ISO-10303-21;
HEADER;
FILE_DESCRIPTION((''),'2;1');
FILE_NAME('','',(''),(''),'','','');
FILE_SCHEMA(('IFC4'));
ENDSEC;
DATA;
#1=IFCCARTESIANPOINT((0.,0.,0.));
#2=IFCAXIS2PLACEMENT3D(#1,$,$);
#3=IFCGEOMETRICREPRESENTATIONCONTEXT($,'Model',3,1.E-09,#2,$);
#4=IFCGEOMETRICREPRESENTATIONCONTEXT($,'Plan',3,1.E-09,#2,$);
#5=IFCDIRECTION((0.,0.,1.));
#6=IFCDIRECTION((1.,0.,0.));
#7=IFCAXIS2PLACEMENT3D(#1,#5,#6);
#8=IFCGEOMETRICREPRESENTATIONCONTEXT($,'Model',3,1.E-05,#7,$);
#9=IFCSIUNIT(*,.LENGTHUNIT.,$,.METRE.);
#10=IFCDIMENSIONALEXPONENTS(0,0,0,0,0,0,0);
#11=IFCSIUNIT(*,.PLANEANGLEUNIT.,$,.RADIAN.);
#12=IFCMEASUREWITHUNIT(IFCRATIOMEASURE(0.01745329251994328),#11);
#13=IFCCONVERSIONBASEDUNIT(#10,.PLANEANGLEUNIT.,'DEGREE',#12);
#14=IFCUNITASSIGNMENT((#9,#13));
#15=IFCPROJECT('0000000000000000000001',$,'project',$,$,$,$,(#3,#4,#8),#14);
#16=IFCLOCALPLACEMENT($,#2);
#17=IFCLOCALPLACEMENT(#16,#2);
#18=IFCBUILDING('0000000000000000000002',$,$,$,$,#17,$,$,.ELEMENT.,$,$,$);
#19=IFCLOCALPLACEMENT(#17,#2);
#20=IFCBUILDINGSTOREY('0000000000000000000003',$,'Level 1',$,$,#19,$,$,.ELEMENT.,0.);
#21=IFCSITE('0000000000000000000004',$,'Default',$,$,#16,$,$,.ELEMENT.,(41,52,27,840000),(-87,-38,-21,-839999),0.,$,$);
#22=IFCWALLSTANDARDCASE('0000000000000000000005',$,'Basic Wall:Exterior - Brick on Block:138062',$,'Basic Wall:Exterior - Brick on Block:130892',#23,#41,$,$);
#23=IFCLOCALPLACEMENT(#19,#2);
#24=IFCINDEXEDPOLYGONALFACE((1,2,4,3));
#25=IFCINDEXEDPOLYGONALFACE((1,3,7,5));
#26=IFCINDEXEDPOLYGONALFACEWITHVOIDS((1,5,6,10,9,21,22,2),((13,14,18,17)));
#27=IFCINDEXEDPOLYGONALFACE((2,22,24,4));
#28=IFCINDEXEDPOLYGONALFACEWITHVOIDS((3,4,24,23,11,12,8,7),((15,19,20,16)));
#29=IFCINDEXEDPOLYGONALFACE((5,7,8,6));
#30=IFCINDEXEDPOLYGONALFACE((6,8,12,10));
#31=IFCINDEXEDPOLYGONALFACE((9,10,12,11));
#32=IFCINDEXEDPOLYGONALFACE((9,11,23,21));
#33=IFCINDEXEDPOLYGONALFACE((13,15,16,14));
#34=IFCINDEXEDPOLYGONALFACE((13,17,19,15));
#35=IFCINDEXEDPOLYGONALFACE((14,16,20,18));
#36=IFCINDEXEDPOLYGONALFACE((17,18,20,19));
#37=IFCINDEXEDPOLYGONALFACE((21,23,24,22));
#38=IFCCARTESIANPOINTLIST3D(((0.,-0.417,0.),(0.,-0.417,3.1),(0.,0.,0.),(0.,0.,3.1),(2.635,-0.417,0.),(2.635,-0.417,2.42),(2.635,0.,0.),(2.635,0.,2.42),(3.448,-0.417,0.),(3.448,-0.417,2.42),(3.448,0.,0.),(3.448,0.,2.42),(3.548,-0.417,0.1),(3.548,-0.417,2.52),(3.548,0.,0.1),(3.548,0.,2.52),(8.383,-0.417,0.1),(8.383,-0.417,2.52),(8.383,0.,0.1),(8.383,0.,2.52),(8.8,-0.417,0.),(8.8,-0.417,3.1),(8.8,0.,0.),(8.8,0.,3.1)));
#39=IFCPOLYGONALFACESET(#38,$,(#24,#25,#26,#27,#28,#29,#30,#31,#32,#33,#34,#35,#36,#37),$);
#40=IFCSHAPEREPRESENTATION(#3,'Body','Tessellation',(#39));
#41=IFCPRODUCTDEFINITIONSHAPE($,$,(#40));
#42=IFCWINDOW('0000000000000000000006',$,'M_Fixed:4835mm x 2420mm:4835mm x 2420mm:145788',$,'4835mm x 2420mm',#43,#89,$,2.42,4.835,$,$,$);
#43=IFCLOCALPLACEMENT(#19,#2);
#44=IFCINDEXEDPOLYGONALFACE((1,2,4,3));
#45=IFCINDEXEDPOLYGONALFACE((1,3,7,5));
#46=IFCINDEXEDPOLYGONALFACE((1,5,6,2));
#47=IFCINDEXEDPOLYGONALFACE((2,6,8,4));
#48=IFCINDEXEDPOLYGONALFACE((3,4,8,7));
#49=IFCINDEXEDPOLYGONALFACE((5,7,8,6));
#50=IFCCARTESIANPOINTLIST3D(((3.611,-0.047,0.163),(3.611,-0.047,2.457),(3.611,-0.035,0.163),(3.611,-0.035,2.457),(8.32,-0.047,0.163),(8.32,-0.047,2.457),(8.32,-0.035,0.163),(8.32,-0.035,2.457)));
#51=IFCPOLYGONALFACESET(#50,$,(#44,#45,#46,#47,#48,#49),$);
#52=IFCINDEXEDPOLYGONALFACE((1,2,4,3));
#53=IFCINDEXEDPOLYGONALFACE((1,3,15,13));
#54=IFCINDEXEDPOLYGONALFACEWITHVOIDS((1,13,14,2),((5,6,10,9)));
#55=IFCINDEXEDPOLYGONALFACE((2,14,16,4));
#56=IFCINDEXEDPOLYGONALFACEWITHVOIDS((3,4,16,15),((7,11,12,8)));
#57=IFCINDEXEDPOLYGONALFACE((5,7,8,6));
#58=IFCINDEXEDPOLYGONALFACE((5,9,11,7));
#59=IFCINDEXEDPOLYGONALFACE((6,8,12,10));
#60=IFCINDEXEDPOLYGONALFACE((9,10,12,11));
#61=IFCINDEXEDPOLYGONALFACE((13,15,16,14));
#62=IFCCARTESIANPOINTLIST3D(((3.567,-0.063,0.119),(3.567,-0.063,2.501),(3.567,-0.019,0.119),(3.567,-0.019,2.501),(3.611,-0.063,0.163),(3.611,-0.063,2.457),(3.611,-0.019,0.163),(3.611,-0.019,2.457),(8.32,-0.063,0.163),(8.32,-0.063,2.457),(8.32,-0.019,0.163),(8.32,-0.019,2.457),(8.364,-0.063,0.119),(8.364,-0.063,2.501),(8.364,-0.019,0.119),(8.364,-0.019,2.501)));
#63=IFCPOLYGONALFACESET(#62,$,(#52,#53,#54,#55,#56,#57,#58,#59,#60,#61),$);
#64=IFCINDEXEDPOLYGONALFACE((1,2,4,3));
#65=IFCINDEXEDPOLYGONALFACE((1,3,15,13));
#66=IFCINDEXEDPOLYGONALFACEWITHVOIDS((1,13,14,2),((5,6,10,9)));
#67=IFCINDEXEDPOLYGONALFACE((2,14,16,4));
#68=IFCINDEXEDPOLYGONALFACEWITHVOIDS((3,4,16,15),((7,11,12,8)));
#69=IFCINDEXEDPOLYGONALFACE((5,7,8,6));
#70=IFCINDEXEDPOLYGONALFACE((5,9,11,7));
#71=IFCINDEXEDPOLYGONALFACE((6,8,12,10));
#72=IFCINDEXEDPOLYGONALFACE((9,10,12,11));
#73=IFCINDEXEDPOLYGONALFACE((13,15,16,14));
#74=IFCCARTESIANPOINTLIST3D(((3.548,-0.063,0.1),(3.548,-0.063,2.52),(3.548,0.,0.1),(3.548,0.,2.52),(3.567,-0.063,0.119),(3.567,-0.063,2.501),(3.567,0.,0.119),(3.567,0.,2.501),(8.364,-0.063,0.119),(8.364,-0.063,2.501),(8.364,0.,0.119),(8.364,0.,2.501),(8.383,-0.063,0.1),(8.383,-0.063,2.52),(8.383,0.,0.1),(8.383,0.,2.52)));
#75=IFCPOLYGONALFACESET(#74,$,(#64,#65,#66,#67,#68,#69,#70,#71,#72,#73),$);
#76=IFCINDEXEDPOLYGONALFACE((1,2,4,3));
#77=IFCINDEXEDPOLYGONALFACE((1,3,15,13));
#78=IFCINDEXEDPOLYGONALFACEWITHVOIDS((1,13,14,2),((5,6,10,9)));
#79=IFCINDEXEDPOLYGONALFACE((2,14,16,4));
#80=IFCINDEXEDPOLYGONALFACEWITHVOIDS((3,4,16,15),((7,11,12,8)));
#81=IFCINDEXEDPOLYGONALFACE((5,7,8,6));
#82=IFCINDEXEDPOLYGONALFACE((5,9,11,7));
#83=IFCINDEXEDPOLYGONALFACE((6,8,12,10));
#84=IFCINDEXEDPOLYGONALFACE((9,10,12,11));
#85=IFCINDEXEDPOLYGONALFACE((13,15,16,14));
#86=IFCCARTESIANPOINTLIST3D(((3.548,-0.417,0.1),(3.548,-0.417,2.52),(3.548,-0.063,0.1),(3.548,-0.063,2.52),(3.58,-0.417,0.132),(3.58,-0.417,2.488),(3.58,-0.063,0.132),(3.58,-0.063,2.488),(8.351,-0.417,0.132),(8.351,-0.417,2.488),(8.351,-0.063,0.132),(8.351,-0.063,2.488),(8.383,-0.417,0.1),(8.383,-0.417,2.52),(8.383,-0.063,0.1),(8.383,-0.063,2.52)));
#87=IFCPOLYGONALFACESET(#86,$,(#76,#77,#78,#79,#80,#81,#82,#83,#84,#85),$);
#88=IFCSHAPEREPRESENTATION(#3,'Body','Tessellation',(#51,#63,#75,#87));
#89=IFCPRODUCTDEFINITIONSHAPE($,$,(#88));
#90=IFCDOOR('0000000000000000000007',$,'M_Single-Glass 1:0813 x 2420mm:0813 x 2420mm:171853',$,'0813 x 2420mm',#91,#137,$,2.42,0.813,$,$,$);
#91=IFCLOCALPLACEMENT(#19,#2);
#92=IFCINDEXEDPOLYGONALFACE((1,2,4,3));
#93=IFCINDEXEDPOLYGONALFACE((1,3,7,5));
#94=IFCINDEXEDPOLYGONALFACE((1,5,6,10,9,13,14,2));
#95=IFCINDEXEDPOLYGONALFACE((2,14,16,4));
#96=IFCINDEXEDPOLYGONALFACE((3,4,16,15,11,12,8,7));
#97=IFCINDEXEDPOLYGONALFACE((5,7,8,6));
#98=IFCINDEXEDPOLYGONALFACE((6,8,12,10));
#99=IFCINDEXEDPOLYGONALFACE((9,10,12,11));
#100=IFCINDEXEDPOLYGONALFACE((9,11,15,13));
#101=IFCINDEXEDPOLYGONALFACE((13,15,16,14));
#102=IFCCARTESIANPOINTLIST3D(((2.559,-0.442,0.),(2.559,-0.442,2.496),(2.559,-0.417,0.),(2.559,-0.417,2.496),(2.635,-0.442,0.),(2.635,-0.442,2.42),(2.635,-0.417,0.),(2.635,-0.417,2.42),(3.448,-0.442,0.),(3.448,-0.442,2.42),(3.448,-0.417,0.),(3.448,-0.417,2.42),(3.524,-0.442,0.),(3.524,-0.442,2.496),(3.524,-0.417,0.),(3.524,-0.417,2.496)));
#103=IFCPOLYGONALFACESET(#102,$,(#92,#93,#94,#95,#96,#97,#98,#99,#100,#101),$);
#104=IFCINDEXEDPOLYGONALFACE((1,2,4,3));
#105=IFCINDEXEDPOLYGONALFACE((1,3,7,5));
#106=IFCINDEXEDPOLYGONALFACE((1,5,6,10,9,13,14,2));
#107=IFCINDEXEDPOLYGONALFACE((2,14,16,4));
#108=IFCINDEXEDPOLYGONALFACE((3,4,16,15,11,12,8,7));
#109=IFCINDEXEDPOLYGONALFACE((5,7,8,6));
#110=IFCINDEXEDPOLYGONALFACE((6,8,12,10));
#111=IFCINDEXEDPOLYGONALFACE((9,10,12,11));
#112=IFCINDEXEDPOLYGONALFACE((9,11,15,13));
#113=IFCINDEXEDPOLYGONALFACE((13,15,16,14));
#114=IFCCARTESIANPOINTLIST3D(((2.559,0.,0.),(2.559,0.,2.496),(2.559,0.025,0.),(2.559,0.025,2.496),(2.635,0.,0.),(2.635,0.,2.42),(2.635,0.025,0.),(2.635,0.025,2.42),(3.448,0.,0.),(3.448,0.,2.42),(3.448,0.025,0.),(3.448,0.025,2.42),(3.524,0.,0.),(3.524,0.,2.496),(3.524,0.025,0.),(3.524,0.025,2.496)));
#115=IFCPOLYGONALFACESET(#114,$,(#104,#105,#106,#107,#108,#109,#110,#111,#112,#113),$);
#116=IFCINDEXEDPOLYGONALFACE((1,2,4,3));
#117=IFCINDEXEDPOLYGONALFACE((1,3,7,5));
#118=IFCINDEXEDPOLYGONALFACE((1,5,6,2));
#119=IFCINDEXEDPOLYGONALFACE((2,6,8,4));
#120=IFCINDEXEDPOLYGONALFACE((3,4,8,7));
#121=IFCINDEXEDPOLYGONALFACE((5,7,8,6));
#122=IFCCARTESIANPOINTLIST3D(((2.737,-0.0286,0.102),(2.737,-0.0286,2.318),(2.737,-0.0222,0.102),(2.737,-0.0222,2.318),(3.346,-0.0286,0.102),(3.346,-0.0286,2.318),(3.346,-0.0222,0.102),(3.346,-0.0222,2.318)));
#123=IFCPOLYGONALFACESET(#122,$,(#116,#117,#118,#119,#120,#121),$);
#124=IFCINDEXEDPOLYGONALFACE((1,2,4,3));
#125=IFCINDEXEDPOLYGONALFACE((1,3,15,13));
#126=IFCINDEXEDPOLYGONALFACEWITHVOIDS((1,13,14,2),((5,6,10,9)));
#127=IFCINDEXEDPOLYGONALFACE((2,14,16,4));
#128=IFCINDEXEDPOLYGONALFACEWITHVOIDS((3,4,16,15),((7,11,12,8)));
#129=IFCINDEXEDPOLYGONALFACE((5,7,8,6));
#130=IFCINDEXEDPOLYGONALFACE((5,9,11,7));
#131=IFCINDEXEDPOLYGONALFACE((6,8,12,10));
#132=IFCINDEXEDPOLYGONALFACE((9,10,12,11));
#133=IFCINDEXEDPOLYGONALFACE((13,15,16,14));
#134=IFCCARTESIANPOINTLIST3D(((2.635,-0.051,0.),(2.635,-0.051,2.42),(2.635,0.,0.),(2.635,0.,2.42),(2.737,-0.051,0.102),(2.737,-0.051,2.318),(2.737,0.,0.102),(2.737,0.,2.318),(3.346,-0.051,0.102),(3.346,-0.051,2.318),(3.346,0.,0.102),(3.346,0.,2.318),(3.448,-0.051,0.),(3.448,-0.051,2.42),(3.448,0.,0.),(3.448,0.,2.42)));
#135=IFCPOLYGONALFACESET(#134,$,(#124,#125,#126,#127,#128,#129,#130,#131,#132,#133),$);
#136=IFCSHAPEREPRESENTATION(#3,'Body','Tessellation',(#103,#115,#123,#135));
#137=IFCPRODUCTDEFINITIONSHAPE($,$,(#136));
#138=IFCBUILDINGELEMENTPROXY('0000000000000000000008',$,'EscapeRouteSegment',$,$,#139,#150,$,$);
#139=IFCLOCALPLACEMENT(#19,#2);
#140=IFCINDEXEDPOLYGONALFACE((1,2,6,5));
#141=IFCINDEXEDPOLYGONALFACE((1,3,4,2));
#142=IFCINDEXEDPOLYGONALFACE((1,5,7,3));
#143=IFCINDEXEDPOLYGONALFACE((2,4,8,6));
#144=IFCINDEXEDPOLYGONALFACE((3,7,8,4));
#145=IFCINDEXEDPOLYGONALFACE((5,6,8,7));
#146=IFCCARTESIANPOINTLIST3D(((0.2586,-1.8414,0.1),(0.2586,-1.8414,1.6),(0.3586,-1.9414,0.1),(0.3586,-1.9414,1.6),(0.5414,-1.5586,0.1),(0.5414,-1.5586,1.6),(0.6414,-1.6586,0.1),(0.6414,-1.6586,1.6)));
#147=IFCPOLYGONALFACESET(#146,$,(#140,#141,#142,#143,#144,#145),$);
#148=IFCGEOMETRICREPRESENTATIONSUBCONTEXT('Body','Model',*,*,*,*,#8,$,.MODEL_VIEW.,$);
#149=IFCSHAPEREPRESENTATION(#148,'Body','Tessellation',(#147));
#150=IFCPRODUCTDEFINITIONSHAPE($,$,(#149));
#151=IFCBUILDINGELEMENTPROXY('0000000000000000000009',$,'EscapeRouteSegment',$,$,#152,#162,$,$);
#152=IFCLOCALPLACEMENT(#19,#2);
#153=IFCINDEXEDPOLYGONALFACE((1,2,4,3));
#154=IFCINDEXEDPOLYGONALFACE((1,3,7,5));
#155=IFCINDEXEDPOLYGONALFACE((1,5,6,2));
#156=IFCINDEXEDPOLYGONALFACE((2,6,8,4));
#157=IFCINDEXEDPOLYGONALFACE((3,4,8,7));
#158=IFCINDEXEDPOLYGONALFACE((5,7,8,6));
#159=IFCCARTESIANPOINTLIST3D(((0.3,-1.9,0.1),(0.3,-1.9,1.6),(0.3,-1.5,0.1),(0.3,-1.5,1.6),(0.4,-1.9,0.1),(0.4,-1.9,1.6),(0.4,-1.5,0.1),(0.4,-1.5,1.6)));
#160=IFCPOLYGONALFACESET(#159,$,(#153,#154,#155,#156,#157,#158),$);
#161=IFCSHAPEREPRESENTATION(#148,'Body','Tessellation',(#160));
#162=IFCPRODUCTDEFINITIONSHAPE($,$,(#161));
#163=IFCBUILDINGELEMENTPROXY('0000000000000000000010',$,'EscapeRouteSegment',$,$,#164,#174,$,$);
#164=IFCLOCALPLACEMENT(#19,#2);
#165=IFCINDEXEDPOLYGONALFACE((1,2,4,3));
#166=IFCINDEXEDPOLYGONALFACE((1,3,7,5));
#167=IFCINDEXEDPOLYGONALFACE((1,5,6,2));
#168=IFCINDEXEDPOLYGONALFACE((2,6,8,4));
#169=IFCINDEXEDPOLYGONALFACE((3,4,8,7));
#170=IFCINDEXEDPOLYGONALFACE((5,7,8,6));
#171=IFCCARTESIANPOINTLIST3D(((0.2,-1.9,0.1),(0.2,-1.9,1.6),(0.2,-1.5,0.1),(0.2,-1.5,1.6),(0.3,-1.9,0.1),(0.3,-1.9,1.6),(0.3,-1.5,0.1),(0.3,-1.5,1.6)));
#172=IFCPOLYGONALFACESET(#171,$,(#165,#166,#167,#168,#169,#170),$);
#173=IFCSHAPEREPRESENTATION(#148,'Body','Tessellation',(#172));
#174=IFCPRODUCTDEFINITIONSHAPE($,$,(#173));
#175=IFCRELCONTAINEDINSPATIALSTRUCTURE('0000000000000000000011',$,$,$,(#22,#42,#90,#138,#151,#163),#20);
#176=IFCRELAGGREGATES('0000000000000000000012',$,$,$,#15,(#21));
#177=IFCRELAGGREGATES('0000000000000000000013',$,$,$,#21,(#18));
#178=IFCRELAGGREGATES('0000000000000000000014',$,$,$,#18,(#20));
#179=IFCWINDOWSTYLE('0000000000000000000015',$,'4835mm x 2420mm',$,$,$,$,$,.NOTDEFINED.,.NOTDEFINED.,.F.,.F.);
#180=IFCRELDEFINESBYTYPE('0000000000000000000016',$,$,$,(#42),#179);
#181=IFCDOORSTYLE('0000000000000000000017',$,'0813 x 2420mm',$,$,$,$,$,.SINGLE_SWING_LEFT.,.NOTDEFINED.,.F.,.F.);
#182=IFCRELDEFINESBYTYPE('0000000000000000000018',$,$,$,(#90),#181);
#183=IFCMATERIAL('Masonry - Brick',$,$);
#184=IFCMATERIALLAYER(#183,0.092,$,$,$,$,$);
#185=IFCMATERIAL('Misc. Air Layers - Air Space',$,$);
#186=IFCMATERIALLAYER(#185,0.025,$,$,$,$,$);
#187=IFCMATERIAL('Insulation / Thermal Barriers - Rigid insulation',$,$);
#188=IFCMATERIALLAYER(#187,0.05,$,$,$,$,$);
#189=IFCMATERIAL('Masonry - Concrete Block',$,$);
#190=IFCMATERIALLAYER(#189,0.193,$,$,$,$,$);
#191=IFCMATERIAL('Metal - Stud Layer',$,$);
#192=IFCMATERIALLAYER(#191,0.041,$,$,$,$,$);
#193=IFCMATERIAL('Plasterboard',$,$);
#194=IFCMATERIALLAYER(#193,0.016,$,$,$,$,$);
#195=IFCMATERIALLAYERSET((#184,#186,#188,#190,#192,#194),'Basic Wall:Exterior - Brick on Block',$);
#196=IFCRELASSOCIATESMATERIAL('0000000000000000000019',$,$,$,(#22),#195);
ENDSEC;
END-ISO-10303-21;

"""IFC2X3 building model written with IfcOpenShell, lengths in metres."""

from ifc_helpers import new_model, entity, si_unit, converted_unit, frame, frame_2d, origin, origin_with_axes, origin_2d_with_axis, place, context, subcontext, project, spatial, polyline, rectangle, outline, extrude, source, transform, mapped, material, layer, layer_set, layer_usage, type_object, type_shapes, element, fill, save


model = new_model("IFC2X3")

# Units and contexts
model_context_1 = context("Model", 3, precision=1e-09, world=origin())
plan_context = context("Plan", 3, precision=1e-09, world=origin())
model_context_2 = context("Model", 3, precision=1e-05, world=origin_with_axes())
body_context = subcontext(model_context_2, "Body", "Model", "MODEL_VIEW")
ifc_project = project(units=[si_unit("LENGTHUNIT", "METRE"), converted_unit("PLANEANGLEUNIT", "DEGREE", entity("IfcRatioMeasure", 0.01745329251994328), si_unit("PLANEANGLEUNIT", "RADIAN"), dimensions=[0, 0, 0, 0, 0, 0, 0])], contexts=[model_context_1, plan_context, model_context_2])

# Site, building, storey
site_placement = place(None, origin())
site = spatial("IfcSite", under=ifc_project, at=site_placement, Name="Default", CompositionType="ELEMENT", RefLatitude=(41, 52, 27, 840000), RefLongitude=(-87, -38, -21, -839999), RefElevation=0.0)
building_placement = place(site_placement, origin())
building = spatial("IfcBuilding", under=site, at=building_placement, CompositionType="ELEMENT")
storey_placement = place(building_placement, origin())
storey = spatial("IfcBuildingStorey", under=building, at=storey_placement, Name="Level 1", CompositionType="ELEMENT", Elevation=0.0)

# Wall, openings, window, door
ifc_material_1 = material(Name="Masonry - Brick")
ifc_layer_1 = layer(ifc_material_1, 0.092)
ifc_material_2 = material(Name="Misc. Air Layers - Air Space")
ifc_layer_2 = layer(ifc_material_2, 0.025)
ifc_material_3 = material(Name="Insulation / Thermal Barriers - Rigid insulation")
ifc_layer_3 = layer(ifc_material_3, 0.05)
ifc_material_4 = material(Name="Masonry - Concrete Block")
ifc_layer_4 = layer(ifc_material_4, 0.193)
ifc_material_5 = material(Name="Metal - Stud Layer")
ifc_layer_5 = layer(ifc_material_5, 0.041)
ifc_material_6 = material(Name="Plasterboard")
ifc_layer_6 = layer(ifc_material_6, 0.016)
ifc_layer_set = layer_set([ifc_layer_1, ifc_layer_2, ifc_layer_3, ifc_layer_4, ifc_layer_5, ifc_layer_6], Name="Basic Wall:Exterior - Brick on Block")
ifc_layer_usage = layer_usage(ifc_layer_set, "AXIS2", "NEGATIVE", 0.2085)
wall_placement = place(storey_placement, frame((0.0, -0.2085, 0.0)))
wall = element("IfcWallStandardCase", 1, at=wall_placement, inside=storey, material=ifc_layer_usage, Name="Basic Wall:Exterior - Brick on Block:138062", ObjectType="Basic Wall:Exterior - Brick on Block:130892", context=model_context_1, shape_type="SweptSolid", body=[
    extrude(rectangle(XDim=8.8, YDim=0.417, at=frame_2d((4.4, 0.0), x_axis=(-1.0, 0.0))), origin(), (0.0, 0.0, 1.0), 3.1),
])
opening_1_placement = place(wall_placement, frame((3.548, -0.2085, 0.1)))
opening_1 = element("IfcOpeningElement", 2, at=opening_1_placement, cuts=wall, ObjectType="Opening", context=model_context_1, shape_type="SweptSolid", body=[
    extrude(rectangle(XDim=2.42, YDim=4.835, at=frame_2d((1.21, 2.4175), x_axis=(1.0, 0.0))), frame((0.0, 0.0, 0.0), z_axis=(0.0, 1.0, 0.0), x_axis=(0.0, 0.0, 1.0)), (0.0, 0.0, 1.0), 0.417),
])
opening_2_placement = place(wall_placement, frame((2.635, -0.2085, 0.0)))
opening_2 = element("IfcOpeningElement", 3, at=opening_2_placement, cuts=wall, ObjectType="Opening", context=model_context_1, shape_type="SweptSolid", body=[
    extrude(rectangle(XDim=0.813, YDim=2.42, at=frame_2d((1.21, 0.4065), x_axis=(0.0, -1.0))), frame((0.0, 0.0, 0.0), z_axis=(0.0, 1.0, 0.0), x_axis=(0.0, 0.0, 1.0)), (0.0, 0.0, 1.0), 0.417),
])
window_style = type_object("IfcWindowStyle", Name="4835mm x 2420mm", ConstructionType="NOTDEFINED", OperationType="NOTDEFINED", ParameterTakesPrecedence=False, Sizeable=False)
shared_shape_1 = source(origin(), model_context_1, "Body", "SweptSolid", [
    extrude(rectangle(XDim=0.012, YDim=4.709, at=origin_2d_with_axis()), frame((2.4175, 0.376, 0.063), z_axis=(0.0, 0.0, 1.0), x_axis=(0.0, -1.0, 0.0)), (0.0, 0.0, 1.0), 2.294),
    extrude(outline(polyline([(-2.3985, -1.191), (2.3985, -1.191), (2.3985, 1.191), (-2.3985, 1.191), (-2.3985, -1.191)]), holes=[polyline([(-2.3545, -1.147), (-2.3545, 1.147), (2.3545, 1.147), (2.3545, -1.147), (-2.3545, -1.147)])]), frame((2.4175, 0.354, 1.21), z_axis=(0.0, 1.0, 0.0), x_axis=(1.0, 0.0, 0.0)), (0.0, 0.0, 1.0), 0.044),
    extrude(outline(polyline([(-2.4175, -1.21), (2.4175, -1.21), (2.4175, 1.21), (-2.4175, 1.21), (-2.4175, -1.21)]), holes=[polyline([(-2.3985, -1.191), (-2.3985, 1.191), (2.3985, 1.191), (2.3985, -1.191), (-2.3985, -1.191)])]), frame((2.4175, 0.354, 1.21), z_axis=(0.0, 1.0, 0.0), x_axis=(1.0, 0.0, 0.0)), (0.0, 0.0, 1.0), 0.063),
    extrude(outline(polyline([(-2.4175, -1.21), (2.4175, -1.21), (2.4175, 1.21), (-2.4175, 1.21), (-2.4175, -1.21)]), holes=[polyline([(-2.3855, -1.178), (-2.3855, 1.178), (2.3855, 1.178), (2.3855, -1.178), (-2.3855, -1.178)])]), frame((2.4175, 0.0, 1.21), z_axis=(0.0, 1.0, 0.0), x_axis=(1.0, 0.0, 0.0)), (0.0, 0.0, 1.0), 0.354),
])
type_shapes(window_style, [shared_shape_1])
window_placement = place(opening_1_placement, origin())
window = element("IfcWindow", 4, at=window_placement, inside=storey, type_object=window_style, Name="M_Fixed:4835mm x 2420mm:4835mm x 2420mm:145788", ObjectType="4835mm x 2420mm", OverallHeight=2.42, OverallWidth=4.835, context=model_context_1, shape_type="MappedRepresentation", body=[
    mapped(shared_shape_1, transform((0.0, 0.0, 0.0), scale=1.0)),
])
fill(opening_1, window)
door_style = type_object("IfcDoorStyle", Name="0813 x 2420mm", ConstructionType="NOTDEFINED", OperationType="SINGLE_SWING_LEFT", ParameterTakesPrecedence=False, Sizeable=False)
shared_shape_2 = source(origin(), model_context_1, "Body", "SweptSolid", [
    extrude(outline(polyline([(-0.4065, -1.191), (-0.4065, 1.229), (-0.4825, 1.229), (-0.4825, -1.267), (0.4825, -1.267), (0.4825, 1.229), (0.4065, 1.229), (0.4065, -1.191), (-0.4065, -1.191)])), frame((0.4065, 0.0, 1.229), z_axis=(0.0, 1.0, 0.0), x_axis=(1.0, 0.0, 0.0)), (0.0, 0.0, -1.0), 0.025),
    extrude(outline(polyline([(-0.4065, -1.191), (-0.4065, 1.229), (-0.4825, 1.229), (-0.4825, -1.267), (0.4825, -1.267), (0.4825, 1.229), (0.4065, 1.229), (0.4065, -1.191), (-0.4065, -1.191)])), frame((0.4065, 0.442, 1.229), z_axis=(0.0, 1.0, 0.0), x_axis=(1.0, 0.0, 0.0)), (0.0, 0.0, -1.0), 0.025),
    extrude(rectangle(XDim=0.609, YDim=0.0064, at=origin_2d_with_axis()), frame((0.4065, 0.3916, 0.102)), (0.0, 0.0, 1.0), 2.216),
    extrude(outline(polyline([(-1.21, -0.4065), (1.21, -0.4065), (1.21, 0.4065), (-1.21, 0.4065), (-1.21, -0.4065)]), holes=[polyline([(-1.108, 0.3045), (1.108, 0.3045), (1.108, -0.3045), (-1.108, -0.3045), (-1.108, 0.3045)])]), frame((0.4065, 0.417, 1.21), z_axis=(0.0, -1.0, 0.0), x_axis=(0.0, 0.0, -1.0)), (0.0, 0.0, 1.0), 0.051),
])
type_shapes(door_style, [shared_shape_2])
door_placement = place(opening_2_placement, origin())
door = element("IfcDoor", 5, at=door_placement, inside=storey, type_object=door_style, Name="M_Single-Glass 1:0813 x 2420mm:0813 x 2420mm:171853", ObjectType="0813 x 2420mm", OverallHeight=2.42, OverallWidth=0.813, context=model_context_1, shape_type="MappedRepresentation", body=[
    mapped(shared_shape_2, transform((0.0, 0.0, 0.0), scale=1.0)),
])
fill(opening_2, door)

# Building element proxies
proxy_1_placement = place(storey_placement, frame((0.5, -1.8, 0.1), z_axis=(0.0, 0.0, 1.0), x_axis=(-0.707107, 0.707106, 0.0)))
element("IfcBuildingElementProxy", 6, at=proxy_1_placement, inside=storey, Name="EscapeRouteSegment", context=body_context, shape_type="SweptSolid", body=[
    extrude(outline(polyline([(0.0, -0.2), (0.0, 0.2), (0.1414, 0.2), (0.1414, -0.2), (0.0, -0.2)])), origin_with_axes(), (0.0, 0.0, 1.0), 1.5),
])
proxy_2_placement = place(storey_placement, frame((0.4, -1.7, 0.1), z_axis=(0.0, 0.0, 1.0), x_axis=(-1.0, 0.0, 0.0)))
element("IfcBuildingElementProxy", 7, at=proxy_2_placement, inside=storey, Name="EscapeRouteSegment", context=body_context, shape_type="SweptSolid", body=[
    extrude(outline(polyline([(0.0, -0.2), (0.0, 0.2), (0.1, 0.2), (0.1, -0.2), (0.0, -0.2)])), origin_with_axes(), (0.0, 0.0, 1.0), 1.5),
])
proxy_3_placement = place(storey_placement, frame((0.3, -1.7, 0.1), z_axis=(0.0, 0.0, 1.0), x_axis=(-1.0, 0.0, 0.0)))
element("IfcBuildingElementProxy", 8, at=proxy_3_placement, inside=storey, Name="EscapeRouteSegment", context=body_context, shape_type="SweptSolid", body=[
    extrude(outline(polyline([(0.0, -0.2), (0.0, 0.2), (0.1, 0.2), (0.1, -0.2), (0.0, -0.2)])), origin_with_axes(), (0.0, 0.0, 1.0), 1.5),
])

save(model, "model.ifc")
